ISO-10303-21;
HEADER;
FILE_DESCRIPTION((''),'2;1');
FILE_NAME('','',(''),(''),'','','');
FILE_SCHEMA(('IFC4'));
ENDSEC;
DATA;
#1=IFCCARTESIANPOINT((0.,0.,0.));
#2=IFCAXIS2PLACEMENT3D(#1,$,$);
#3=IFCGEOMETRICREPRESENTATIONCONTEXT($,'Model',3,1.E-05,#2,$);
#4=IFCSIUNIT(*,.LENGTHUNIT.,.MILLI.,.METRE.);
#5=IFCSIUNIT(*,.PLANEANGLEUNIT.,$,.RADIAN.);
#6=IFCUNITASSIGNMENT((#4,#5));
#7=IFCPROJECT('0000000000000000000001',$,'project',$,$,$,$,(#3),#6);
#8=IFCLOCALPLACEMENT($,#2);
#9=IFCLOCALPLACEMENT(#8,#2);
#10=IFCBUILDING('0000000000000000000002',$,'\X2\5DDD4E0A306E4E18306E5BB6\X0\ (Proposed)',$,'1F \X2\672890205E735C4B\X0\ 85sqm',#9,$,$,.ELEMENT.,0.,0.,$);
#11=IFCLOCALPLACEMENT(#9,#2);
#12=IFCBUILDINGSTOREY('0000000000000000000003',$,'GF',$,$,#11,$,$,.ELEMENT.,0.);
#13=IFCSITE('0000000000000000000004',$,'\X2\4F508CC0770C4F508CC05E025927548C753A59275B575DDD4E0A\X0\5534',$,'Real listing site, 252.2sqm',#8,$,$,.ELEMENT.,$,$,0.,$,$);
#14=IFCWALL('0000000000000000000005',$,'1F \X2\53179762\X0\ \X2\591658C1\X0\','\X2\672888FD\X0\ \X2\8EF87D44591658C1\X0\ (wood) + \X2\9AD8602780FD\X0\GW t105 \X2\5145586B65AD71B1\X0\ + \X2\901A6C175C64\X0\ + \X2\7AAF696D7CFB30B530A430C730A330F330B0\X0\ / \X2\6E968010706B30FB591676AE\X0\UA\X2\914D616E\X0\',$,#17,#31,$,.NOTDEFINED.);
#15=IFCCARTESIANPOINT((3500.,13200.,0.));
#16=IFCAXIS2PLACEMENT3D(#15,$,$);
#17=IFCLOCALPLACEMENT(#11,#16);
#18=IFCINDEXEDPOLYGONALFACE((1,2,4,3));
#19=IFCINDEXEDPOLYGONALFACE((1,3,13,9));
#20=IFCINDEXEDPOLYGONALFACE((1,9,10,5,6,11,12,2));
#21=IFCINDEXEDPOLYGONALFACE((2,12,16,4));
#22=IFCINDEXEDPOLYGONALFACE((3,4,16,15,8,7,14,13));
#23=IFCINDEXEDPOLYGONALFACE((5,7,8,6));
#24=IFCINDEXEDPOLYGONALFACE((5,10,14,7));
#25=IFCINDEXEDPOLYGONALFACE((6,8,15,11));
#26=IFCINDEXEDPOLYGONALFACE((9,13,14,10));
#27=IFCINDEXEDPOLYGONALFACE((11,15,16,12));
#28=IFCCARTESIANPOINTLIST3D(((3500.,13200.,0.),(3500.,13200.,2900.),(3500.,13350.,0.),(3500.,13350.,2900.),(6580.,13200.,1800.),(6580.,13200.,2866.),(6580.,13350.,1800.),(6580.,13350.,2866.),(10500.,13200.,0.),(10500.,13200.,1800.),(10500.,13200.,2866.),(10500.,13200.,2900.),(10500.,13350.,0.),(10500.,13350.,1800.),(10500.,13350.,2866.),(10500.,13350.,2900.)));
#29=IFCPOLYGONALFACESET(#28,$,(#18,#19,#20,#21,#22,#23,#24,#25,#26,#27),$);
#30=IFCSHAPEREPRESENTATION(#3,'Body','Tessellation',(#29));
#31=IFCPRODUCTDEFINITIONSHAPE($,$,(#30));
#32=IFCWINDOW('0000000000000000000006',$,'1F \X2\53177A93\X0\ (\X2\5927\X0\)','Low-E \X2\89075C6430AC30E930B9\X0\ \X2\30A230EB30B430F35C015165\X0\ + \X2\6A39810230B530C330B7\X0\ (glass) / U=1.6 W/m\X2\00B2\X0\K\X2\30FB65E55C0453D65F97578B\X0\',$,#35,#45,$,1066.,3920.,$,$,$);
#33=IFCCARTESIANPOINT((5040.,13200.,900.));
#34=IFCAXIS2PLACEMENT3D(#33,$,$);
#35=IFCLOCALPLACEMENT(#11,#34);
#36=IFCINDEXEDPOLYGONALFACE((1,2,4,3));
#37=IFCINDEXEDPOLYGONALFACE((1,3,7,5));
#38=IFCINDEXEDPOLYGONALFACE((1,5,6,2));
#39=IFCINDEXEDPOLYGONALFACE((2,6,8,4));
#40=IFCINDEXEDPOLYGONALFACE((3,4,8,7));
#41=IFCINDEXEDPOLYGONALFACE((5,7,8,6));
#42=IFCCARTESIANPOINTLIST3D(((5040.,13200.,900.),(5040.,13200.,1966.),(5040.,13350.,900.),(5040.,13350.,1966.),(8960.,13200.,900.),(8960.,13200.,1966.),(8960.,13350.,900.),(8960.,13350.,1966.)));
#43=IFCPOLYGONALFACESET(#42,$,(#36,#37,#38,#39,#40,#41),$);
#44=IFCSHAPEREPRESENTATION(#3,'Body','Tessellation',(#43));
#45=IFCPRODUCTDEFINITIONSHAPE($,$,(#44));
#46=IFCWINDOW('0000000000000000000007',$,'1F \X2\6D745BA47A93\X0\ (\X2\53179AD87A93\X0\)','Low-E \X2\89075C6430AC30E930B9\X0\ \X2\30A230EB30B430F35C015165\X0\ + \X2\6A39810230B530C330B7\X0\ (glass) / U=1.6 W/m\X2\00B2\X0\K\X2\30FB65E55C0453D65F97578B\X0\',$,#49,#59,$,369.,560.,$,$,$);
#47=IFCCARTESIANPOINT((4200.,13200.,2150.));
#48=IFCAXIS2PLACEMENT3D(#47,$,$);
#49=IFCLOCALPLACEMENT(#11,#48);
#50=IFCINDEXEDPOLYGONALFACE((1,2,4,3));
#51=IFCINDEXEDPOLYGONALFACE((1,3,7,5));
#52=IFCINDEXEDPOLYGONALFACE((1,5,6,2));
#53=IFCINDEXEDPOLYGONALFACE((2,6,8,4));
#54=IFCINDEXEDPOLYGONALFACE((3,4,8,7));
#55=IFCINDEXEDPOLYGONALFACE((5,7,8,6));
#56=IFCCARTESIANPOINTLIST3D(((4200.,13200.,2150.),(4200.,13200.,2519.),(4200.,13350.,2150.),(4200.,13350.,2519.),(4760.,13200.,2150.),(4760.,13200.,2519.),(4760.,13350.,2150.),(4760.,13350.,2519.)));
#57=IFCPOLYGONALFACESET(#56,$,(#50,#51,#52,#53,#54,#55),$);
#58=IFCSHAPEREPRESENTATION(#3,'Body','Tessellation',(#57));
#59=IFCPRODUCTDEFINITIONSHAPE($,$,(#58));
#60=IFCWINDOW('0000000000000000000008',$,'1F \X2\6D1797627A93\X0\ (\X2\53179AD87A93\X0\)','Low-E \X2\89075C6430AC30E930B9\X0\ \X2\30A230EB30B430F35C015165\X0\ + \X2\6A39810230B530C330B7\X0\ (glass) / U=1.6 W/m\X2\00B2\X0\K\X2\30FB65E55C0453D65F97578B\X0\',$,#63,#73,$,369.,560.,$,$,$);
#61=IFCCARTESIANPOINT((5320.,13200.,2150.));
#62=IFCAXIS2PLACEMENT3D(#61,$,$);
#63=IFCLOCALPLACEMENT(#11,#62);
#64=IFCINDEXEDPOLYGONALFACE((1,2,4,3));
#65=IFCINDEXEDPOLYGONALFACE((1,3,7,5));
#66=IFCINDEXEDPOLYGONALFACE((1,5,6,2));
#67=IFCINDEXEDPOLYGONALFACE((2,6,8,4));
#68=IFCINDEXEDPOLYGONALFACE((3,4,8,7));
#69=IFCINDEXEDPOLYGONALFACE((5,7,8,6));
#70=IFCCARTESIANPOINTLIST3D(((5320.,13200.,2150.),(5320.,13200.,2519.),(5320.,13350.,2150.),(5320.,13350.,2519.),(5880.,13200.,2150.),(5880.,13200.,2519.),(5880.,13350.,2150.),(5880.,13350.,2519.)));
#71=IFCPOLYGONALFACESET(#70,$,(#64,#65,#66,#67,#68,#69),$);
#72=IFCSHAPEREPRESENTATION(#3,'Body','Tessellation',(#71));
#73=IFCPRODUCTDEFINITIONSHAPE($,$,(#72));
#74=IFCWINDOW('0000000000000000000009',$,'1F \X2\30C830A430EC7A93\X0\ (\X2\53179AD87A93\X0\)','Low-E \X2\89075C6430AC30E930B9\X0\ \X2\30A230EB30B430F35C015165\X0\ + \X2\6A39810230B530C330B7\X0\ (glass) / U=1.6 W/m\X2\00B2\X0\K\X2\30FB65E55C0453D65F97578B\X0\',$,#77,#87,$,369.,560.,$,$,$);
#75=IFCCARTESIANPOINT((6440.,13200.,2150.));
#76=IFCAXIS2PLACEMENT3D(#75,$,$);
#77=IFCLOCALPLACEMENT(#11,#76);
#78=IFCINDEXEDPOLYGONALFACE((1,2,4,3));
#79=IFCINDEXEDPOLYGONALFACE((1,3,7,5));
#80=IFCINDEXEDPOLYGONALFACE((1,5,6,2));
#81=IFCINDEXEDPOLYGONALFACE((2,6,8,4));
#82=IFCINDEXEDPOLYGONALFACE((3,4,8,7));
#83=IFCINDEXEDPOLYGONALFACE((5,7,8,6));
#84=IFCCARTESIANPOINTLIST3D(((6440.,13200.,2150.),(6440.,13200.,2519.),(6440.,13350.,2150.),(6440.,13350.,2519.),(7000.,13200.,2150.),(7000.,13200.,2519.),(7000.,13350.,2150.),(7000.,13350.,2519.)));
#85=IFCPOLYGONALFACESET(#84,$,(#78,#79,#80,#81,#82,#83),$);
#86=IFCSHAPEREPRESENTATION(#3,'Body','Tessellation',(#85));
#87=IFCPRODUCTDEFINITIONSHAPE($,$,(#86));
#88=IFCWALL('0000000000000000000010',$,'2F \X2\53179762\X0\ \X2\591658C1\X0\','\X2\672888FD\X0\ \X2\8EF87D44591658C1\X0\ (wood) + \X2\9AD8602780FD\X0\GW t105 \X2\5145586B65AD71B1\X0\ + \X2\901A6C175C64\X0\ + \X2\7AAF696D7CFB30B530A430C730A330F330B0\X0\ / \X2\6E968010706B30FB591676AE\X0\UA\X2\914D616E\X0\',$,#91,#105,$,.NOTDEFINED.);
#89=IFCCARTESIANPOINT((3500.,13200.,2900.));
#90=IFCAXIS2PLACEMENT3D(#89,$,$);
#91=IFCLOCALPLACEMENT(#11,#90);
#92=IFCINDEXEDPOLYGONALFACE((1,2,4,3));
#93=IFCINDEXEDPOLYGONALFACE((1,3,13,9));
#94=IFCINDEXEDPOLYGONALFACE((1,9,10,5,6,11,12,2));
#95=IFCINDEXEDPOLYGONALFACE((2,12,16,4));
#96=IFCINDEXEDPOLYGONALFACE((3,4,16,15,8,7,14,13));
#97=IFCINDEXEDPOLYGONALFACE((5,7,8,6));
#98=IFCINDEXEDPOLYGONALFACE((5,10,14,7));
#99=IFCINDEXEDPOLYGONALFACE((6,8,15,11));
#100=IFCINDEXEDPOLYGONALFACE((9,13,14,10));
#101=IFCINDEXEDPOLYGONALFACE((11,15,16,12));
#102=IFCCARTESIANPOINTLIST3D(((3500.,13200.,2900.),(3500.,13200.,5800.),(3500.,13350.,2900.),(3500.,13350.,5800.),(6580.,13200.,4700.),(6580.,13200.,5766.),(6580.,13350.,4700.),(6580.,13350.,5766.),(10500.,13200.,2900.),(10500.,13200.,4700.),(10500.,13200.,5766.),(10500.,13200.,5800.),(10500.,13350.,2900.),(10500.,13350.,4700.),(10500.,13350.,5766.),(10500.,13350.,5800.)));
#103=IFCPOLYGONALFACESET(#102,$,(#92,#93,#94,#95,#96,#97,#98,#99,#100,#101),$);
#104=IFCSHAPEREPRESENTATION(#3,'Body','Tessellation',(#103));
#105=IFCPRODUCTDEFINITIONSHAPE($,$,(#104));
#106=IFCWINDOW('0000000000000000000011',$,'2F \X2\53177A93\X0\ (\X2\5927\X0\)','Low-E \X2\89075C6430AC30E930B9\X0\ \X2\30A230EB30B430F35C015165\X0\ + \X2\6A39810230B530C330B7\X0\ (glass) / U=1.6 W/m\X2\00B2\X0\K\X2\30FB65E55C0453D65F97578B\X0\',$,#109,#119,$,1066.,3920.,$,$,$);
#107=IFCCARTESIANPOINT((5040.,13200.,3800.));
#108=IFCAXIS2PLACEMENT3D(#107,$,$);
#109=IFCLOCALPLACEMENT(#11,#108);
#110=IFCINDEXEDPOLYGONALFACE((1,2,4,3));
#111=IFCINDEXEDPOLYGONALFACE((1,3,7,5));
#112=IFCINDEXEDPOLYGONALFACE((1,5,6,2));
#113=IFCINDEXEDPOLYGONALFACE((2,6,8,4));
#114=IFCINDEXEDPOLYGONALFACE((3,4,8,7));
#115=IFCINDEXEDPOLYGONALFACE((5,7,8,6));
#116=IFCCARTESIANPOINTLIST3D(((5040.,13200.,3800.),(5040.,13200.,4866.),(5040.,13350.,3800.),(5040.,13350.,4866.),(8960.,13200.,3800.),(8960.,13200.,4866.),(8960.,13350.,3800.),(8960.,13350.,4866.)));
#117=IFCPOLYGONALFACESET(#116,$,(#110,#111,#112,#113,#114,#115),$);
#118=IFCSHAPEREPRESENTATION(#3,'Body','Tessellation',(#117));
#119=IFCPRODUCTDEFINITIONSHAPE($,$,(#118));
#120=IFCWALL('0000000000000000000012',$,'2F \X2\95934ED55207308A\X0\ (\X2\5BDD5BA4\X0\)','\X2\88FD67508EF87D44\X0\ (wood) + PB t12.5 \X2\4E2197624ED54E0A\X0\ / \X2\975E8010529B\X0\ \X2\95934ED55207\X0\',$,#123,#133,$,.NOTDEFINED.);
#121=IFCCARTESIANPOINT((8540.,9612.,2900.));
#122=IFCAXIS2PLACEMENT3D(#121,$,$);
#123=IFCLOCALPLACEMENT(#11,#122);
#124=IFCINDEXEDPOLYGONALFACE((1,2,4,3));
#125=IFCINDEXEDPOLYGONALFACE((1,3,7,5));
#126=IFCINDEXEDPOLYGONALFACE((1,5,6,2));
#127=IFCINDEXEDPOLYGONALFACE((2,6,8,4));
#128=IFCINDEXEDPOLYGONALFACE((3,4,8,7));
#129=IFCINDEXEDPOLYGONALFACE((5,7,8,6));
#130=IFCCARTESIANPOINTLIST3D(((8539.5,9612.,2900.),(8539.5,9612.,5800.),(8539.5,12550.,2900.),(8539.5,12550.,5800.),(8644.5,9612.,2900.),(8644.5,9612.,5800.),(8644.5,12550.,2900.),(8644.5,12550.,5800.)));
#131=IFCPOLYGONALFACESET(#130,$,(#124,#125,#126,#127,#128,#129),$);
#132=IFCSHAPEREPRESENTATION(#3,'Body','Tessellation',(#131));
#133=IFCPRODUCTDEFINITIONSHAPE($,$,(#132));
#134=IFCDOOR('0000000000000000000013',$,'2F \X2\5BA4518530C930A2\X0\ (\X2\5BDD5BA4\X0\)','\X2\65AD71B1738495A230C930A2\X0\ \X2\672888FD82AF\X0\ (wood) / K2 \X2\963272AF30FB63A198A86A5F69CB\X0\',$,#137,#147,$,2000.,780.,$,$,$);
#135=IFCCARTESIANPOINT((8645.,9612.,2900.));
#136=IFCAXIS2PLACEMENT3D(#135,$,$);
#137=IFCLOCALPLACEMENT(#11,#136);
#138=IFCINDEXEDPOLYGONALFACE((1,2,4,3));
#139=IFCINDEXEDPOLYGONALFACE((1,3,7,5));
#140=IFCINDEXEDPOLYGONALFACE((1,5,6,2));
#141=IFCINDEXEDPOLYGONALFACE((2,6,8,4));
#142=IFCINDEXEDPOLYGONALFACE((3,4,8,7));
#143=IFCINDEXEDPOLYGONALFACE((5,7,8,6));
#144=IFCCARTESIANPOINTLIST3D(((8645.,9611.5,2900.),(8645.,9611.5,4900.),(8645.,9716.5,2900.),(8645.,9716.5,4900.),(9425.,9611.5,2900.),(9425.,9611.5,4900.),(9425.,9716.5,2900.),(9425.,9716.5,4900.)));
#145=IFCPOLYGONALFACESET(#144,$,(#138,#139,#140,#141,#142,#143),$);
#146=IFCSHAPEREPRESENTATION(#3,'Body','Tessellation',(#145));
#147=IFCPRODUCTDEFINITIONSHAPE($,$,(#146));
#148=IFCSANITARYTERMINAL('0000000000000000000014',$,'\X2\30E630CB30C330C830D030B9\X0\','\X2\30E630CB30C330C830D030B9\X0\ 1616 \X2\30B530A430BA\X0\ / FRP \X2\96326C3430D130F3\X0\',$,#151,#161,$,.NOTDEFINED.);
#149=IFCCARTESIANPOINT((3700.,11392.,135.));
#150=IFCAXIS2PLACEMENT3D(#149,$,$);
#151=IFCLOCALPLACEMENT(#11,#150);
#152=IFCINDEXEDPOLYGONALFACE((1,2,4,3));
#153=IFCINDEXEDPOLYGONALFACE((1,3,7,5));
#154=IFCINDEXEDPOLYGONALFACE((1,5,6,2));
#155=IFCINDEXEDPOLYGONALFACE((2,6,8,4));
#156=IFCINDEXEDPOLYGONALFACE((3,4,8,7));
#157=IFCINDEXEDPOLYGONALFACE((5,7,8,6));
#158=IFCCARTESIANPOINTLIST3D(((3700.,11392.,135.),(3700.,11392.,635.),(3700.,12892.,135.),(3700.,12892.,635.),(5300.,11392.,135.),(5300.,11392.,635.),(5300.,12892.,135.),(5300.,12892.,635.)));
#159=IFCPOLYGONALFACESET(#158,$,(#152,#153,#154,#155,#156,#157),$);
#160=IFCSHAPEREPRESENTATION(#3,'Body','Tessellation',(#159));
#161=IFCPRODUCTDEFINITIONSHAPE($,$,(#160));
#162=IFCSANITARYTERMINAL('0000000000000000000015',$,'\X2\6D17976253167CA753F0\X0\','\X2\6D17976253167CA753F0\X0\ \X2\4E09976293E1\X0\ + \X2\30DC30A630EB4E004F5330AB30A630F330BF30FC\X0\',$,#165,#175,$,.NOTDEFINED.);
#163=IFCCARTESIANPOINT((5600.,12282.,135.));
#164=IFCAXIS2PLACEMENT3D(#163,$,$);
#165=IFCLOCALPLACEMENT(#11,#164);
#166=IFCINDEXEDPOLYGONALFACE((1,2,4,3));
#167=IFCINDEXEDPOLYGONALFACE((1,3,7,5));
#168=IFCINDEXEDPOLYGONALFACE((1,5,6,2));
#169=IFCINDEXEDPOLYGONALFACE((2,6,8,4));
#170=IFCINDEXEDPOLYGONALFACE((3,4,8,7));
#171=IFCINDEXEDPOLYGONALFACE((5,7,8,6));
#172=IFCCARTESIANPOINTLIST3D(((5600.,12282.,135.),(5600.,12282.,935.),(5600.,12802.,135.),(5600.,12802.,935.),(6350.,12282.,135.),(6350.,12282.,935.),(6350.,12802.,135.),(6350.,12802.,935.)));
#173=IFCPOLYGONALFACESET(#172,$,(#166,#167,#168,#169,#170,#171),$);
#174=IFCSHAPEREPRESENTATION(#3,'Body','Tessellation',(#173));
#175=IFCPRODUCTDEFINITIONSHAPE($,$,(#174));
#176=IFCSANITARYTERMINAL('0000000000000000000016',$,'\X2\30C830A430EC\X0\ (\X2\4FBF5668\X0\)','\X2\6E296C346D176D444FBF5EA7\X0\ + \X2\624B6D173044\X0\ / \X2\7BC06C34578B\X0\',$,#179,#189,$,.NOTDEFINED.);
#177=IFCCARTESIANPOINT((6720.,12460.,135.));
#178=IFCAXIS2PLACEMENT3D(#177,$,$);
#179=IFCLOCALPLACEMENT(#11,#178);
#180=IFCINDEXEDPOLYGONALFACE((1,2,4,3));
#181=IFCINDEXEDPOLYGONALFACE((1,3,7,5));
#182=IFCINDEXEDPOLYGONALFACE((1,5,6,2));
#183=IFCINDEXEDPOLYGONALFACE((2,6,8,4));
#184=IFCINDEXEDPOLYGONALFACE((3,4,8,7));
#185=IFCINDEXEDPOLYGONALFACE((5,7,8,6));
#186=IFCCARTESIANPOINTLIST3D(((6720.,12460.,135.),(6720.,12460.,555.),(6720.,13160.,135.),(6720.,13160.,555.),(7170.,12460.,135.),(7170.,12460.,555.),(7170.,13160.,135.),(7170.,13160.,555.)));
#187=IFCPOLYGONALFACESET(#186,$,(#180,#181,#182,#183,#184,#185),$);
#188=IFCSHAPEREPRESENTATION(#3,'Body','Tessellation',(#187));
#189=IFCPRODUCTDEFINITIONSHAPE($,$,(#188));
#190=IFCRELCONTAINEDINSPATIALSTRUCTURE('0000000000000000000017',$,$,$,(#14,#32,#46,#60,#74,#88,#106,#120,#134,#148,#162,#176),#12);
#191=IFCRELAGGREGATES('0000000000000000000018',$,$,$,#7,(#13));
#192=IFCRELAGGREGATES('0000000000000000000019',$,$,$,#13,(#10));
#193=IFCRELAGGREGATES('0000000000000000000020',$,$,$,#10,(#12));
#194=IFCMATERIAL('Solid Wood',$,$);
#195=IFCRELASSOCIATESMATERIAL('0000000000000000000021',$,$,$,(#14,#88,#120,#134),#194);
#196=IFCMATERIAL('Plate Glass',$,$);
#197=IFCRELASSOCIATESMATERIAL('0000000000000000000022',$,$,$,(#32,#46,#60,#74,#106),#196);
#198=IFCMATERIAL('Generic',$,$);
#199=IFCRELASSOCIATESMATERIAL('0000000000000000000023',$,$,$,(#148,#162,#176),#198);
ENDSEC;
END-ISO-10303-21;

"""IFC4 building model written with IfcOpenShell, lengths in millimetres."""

from ifc_helpers import new_model, si_unit, frame, frame_2d, origin, place, context, project, spatial, rectangle, extrude, material, element, fill, save


model = new_model("IFC4")

# Units and contexts
model_context = context("Model", 3, precision=1e-05, world=origin())
ifc_project = project(units=[si_unit("LENGTHUNIT", "METRE", prefix="MILLI"), si_unit("PLANEANGLEUNIT", "RADIAN")], contexts=[model_context])

# Site, building, storey
site_placement = place(None, origin())
site = spatial("IfcSite", under=ifc_project, at=site_placement, Name="佐賀県佐賀市大和町大字川上5534", ObjectType="Real listing site, 252.2sqm", CompositionType="ELEMENT", RefElevation=0.0)
building_placement = place(site_placement, origin())
building = spatial("IfcBuilding", under=site, at=building_placement, Name="川上の丘の家 (Proposed)", ObjectType="1F 木造平屋 85sqm", CompositionType="ELEMENT", ElevationOfRefHeight=0.0, ElevationOfTerrain=0.0)
storey_placement = place(building_placement, origin())
storey = spatial("IfcBuildingStorey", under=building, at=storey_placement, Name="GF", CompositionType="ELEMENT", Elevation=0.0)

# Wall, openings, windows
ifc_material_1 = material(Name="Solid Wood")
wall_1_placement = place(storey_placement, frame((3500.0, 13200.0, 0.0)))
wall_1 = element("IfcWall", 1, at=wall_1_placement, inside=storey, material=ifc_material_1, Name="1F 北面 外壁", Description="木製 軸組外壁 (wood) + 高性能GW t105 充填断熱 + 通気層 + 窯業系サイディング / 準耐火・外皮UA配慮", PredefinedType="NOTDEFINED", context=model_context, shape_type="SweptSolid", body=[
    extrude(rectangle(XDim=7000.0, YDim=150.0, at=frame_2d((3500.0, 75.0))), frame((3500.0, 13200.0, 0.0)), (0.0, 0.0, 1.0), 2900.0),
])
opening_1_placement = place(storey_placement, frame((5040.0, 13200.0, 900.0)))
opening_1 = element("IfcOpeningElement", 2, at=opening_1_placement, cuts=wall_1, PredefinedType="NOTDEFINED", context=model_context, shape_type="SweptSolid", body=[
    extrude(rectangle(XDim=3920.0, YDim=150.0, at=frame_2d((1960.0, 75.0))), frame((5040.0, 13200.0, 900.0)), (0.0, 0.0, 1.0), 1066.0),
])
opening_2_placement = place(storey_placement, frame((4200.0, 13200.0, 2150.0)))
opening_2 = element("IfcOpeningElement", 3, at=opening_2_placement, cuts=wall_1, PredefinedType="NOTDEFINED", context=model_context, shape_type="SweptSolid", body=[
    extrude(rectangle(XDim=560.0, YDim=150.0, at=frame_2d((280.0, 75.0))), frame((4200.0, 13200.0, 2150.0)), (0.0, 0.0, 1.0), 369.0),
])
opening_3_placement = place(storey_placement, frame((5320.0, 13200.0, 2150.0)))
opening_3 = element("IfcOpeningElement", 4, at=opening_3_placement, cuts=wall_1, PredefinedType="NOTDEFINED", context=model_context, shape_type="SweptSolid", body=[
    extrude(rectangle(XDim=560.0, YDim=150.0, at=frame_2d((280.0, 75.0))), frame((5320.0, 13200.0, 2150.0)), (0.0, 0.0, 1.0), 369.0),
])
opening_4_placement = place(storey_placement, frame((6440.0, 13200.0, 2150.0)))
opening_4 = element("IfcOpeningElement", 5, at=opening_4_placement, cuts=wall_1, PredefinedType="NOTDEFINED", context=model_context, shape_type="SweptSolid", body=[
    extrude(rectangle(XDim=560.0, YDim=150.0, at=frame_2d((280.0, 75.0))), frame((6440.0, 13200.0, 2150.0)), (0.0, 0.0, 1.0), 369.0),
])
ifc_material_2 = material(Name="Plate Glass")
window_1_placement = place(storey_placement, frame((5040.0, 13200.0, 900.0)))
window_1 = element("IfcWindow", 6, at=window_1_placement, inside=storey, material=ifc_material_2, Name="1F 北窓 (大)", Description="Low-E 複層ガラス アルゴン封入 + 樹脂サッシ (glass) / U=1.6 W/m²K・日射取得型", OverallHeight=1066.0, OverallWidth=3920.0, context=model_context, shape_type="SweptSolid", body=[
    extrude(rectangle(XDim=3920.0, YDim=150.0, at=frame_2d((1960.0, 75.0))), frame((5040.0, 13200.0, 900.0)), (0.0, 0.0, 1.0), 1066.0),
])
fill(opening_1, window_1)
window_2_placement = place(storey_placement, frame((4200.0, 13200.0, 2150.0)))
window_2 = element("IfcWindow", 7, at=window_2_placement, inside=storey, material=ifc_material_2, Name="1F 浴室窓 (北高窓)", Description="Low-E 複層ガラス アルゴン封入 + 樹脂サッシ (glass) / U=1.6 W/m²K・日射取得型", OverallHeight=369.0, OverallWidth=560.0, context=model_context, shape_type="SweptSolid", body=[
    extrude(rectangle(XDim=560.0, YDim=150.0, at=frame_2d((280.0, 75.0))), frame((4200.0, 13200.0, 2150.0)), (0.0, 0.0, 1.0), 369.0),
])
fill(opening_2, window_2)
window_3_placement = place(storey_placement, frame((5320.0, 13200.0, 2150.0)))
window_3 = element("IfcWindow", 8, at=window_3_placement, inside=storey, material=ifc_material_2, Name="1F 洗面窓 (北高窓)", Description="Low-E 複層ガラス アルゴン封入 + 樹脂サッシ (glass) / U=1.6 W/m²K・日射取得型", OverallHeight=369.0, OverallWidth=560.0, context=model_context, shape_type="SweptSolid", body=[
    extrude(rectangle(XDim=560.0, YDim=150.0, at=frame_2d((280.0, 75.0))), frame((5320.0, 13200.0, 2150.0)), (0.0, 0.0, 1.0), 369.0),
])
fill(opening_3, window_3)
window_4_placement = place(storey_placement, frame((6440.0, 13200.0, 2150.0)))
window_4 = element("IfcWindow", 9, at=window_4_placement, inside=storey, material=ifc_material_2, Name="1F トイレ窓 (北高窓)", Description="Low-E 複層ガラス アルゴン封入 + 樹脂サッシ (glass) / U=1.6 W/m²K・日射取得型", OverallHeight=369.0, OverallWidth=560.0, context=model_context, shape_type="SweptSolid", body=[
    extrude(rectangle(XDim=560.0, YDim=150.0, at=frame_2d((280.0, 75.0))), frame((6440.0, 13200.0, 2150.0)), (0.0, 0.0, 1.0), 369.0),
])
fill(opening_4, window_4)

# Wall, opening, window
wall_2_placement = place(storey_placement, frame((3500.0, 13200.0, 2900.0)))
wall_2 = element("IfcWall", 10, at=wall_2_placement, inside=storey, material=ifc_material_1, Name="2F 北面 外壁", Description="木製 軸組外壁 (wood) + 高性能GW t105 充填断熱 + 通気層 + 窯業系サイディング / 準耐火・外皮UA配慮", PredefinedType="NOTDEFINED", context=model_context, shape_type="SweptSolid", body=[
    extrude(rectangle(XDim=7000.0, YDim=150.0, at=frame_2d((3500.0, 75.0))), frame((3500.0, 13200.0, 2900.0)), (0.0, 0.0, 1.0), 2900.0),
])
opening_5_placement = place(storey_placement, frame((5040.0, 13200.0, 3800.0)))
opening_5 = element("IfcOpeningElement", 11, at=opening_5_placement, cuts=wall_2, PredefinedType="NOTDEFINED", context=model_context, shape_type="SweptSolid", body=[
    extrude(rectangle(XDim=3920.0, YDim=150.0, at=frame_2d((1960.0, 75.0))), frame((5040.0, 13200.0, 3800.0)), (0.0, 0.0, 1.0), 1066.0),
])
window_5_placement = place(storey_placement, frame((5040.0, 13200.0, 3800.0)))
window_5 = element("IfcWindow", 12, at=window_5_placement, inside=storey, material=ifc_material_2, Name="2F 北窓 (大)", Description="Low-E 複層ガラス アルゴン封入 + 樹脂サッシ (glass) / U=1.6 W/m²K・日射取得型", OverallHeight=1066.0, OverallWidth=3920.0, context=model_context, shape_type="SweptSolid", body=[
    extrude(rectangle(XDim=3920.0, YDim=150.0, at=frame_2d((1960.0, 75.0))), frame((5040.0, 13200.0, 3800.0)), (0.0, 0.0, 1.0), 1066.0),
])
fill(opening_5, window_5)

# Wall
wall_3_placement = place(storey_placement, frame((8540.0, 9612.0, 2900.0)))
element("IfcWall", 13, at=wall_3_placement, inside=storey, material=ifc_material_1, Name="2F 間仕切り (寝室)", Description="製材軸組 (wood) + PB t12.5 両面仕上 / 非耐力 間仕切", PredefinedType="NOTDEFINED", context=model_context, shape_type="SweptSolid", body=[
    extrude(rectangle(XDim=105.0, YDim=2938.0, at=frame_2d((52.0, 1469.0))), frame((8540.0, 9612.0, 2900.0)), (0.0, 0.0, 1.0), 2900.0),
])

# Door
door_1_placement = place(storey_placement, frame((8645.0, 9612.0, 2900.0)))
element("IfcDoor", 14, at=door_1_placement, inside=storey, material=ifc_material_1, Name="2F 室内ドア (寝室)", Description="断熱玄関ドア 木製芯 (wood) / K2 防犯・採風機構", OverallHeight=2000.0, OverallWidth=780.0, context=model_context, shape_type="SweptSolid", body=[
    extrude(rectangle(XDim=780.0, YDim=105.0, at=frame_2d((390.0, 52.0))), frame((8645.0, 9612.0, 2900.0)), (0.0, 0.0, 1.0), 2000.0),
])

# Sanitary terminals
ifc_material_3 = material(Name="Generic")
sanitary_terminal_1_placement = place(storey_placement, frame((3700.0, 11392.0, 135.0)))
element("IfcSanitaryTerminal", 15, at=sanitary_terminal_1_placement, inside=storey, material=ifc_material_3, Name="ユニットバス", Description="ユニットバス 1616 サイズ / FRP 防水パン", PredefinedType="NOTDEFINED", context=model_context, shape_type="SweptSolid", body=[
    extrude(rectangle(XDim=1600.0, YDim=1500.0, at=frame_2d((800.0, 750.0))), frame((3700.0, 11392.0, 135.0)), (0.0, 0.0, 1.0), 500.0),
])
sanitary_terminal_2_placement = place(storey_placement, frame((5600.0, 12282.0, 135.0)))
element("IfcSanitaryTerminal", 16, at=sanitary_terminal_2_placement, inside=storey, material=ifc_material_3, Name="洗面化粧台", Description="洗面化粧台 三面鏡 + ボウル一体カウンター", PredefinedType="NOTDEFINED", context=model_context, shape_type="SweptSolid", body=[
    extrude(rectangle(XDim=750.0, YDim=520.0, at=frame_2d((375.0, 260.0))), frame((5600.0, 12282.0, 135.0)), (0.0, 0.0, 1.0), 800.0),
])
sanitary_terminal_3_placement = place(storey_placement, frame((6720.0, 12460.0, 135.0)))
element("IfcSanitaryTerminal", 17, at=sanitary_terminal_3_placement, inside=storey, material=ifc_material_3, Name="トイレ (便器)", Description="温水洗浄便座 + 手洗い / 節水型", PredefinedType="NOTDEFINED", context=model_context, shape_type="SweptSolid", body=[
    extrude(rectangle(XDim=450.0, YDim=700.0, at=frame_2d((225.0, 350.0))), frame((6720.0, 12460.0, 135.0)), (0.0, 0.0, 1.0), 420.0),
])

save(model, "model.ifc")
